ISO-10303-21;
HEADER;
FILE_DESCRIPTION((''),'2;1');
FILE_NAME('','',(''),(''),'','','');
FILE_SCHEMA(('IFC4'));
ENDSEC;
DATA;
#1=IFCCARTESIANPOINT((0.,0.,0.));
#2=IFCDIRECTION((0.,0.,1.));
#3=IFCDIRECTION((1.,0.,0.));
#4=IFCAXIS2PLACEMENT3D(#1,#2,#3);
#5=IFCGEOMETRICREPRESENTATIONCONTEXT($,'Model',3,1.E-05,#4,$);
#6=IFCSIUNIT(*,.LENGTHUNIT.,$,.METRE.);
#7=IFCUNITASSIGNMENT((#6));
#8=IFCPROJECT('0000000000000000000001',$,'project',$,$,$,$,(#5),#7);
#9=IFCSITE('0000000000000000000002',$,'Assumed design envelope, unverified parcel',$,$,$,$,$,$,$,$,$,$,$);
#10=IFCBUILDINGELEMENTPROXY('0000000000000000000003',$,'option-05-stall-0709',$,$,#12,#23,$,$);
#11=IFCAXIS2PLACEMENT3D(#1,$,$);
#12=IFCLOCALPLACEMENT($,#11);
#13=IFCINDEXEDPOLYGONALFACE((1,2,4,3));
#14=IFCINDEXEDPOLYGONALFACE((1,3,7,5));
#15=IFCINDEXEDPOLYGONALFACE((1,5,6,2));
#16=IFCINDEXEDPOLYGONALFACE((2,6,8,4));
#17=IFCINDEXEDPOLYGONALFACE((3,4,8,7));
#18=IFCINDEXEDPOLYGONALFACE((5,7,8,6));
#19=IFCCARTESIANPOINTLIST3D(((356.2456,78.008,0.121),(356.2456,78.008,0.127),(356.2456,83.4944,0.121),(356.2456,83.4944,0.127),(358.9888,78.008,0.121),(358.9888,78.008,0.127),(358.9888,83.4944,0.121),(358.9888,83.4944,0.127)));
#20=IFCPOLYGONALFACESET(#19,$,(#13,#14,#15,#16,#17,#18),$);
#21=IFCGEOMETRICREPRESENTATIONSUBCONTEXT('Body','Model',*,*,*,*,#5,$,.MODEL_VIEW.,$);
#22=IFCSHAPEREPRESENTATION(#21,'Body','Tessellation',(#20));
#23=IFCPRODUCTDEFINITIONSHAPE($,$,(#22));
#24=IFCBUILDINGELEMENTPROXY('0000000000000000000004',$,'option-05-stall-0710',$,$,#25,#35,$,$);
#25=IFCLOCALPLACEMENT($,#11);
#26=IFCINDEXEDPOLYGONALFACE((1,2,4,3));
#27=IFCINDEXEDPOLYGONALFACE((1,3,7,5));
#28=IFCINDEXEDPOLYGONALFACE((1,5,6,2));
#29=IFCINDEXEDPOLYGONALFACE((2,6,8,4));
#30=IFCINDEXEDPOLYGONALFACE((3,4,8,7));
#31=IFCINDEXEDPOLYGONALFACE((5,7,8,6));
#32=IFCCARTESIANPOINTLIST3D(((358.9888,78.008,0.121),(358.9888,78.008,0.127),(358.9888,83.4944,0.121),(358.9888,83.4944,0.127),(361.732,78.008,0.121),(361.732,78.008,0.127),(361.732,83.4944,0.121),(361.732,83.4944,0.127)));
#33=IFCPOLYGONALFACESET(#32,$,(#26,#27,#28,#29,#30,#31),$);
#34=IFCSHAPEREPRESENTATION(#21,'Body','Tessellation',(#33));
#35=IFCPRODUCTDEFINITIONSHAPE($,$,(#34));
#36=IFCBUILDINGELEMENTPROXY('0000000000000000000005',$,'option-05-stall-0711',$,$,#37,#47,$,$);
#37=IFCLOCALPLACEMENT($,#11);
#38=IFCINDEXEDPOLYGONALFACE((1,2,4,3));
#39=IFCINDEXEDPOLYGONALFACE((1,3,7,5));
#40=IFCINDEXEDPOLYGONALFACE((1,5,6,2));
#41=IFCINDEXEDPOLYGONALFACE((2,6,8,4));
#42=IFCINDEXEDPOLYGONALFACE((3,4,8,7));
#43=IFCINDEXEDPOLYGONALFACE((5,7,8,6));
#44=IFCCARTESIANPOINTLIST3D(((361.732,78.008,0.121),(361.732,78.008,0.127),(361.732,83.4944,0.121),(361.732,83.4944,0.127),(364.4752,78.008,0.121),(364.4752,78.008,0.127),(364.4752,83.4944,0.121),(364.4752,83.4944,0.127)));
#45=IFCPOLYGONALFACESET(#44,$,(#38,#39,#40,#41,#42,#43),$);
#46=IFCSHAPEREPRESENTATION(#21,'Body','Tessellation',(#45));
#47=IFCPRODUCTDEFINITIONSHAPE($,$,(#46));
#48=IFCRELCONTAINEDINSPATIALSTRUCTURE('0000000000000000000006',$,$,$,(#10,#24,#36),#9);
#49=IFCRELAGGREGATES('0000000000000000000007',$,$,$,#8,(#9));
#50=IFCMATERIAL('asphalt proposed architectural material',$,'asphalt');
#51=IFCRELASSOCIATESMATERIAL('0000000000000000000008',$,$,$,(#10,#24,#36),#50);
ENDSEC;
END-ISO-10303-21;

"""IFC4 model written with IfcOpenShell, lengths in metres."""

from ifc_helpers import new_model, si_unit, frame, origin_with_axes, place, context, subcontext, project, spatial, rectangle, extrude, material, element, save


model = new_model("IFC4")

# Units and contexts
model_context = context("Model", 3, precision=1e-05, world=origin_with_axes())
body_context = subcontext(model_context, "Body", "Model", "MODEL_VIEW")
ifc_project = project(units=[si_unit("LENGTHUNIT", "METRE")], contexts=[model_context])

# Site
site = spatial("IfcSite", under=ifc_project, Name="Assumed design envelope, unverified parcel")

# Building element proxies
ifc_material = material(Name="asphalt proposed architectural material", Category="asphalt")
for number, where, z_axis, x_axis, name in (
    (1, (357.6172, 80.7512, 0.121), (0.0, 0.0, 1.0), (1.0, 0.0, 0.0), "option-05-stall-0709"),
    (2, (360.3604, 80.7512, 0.121), (0.0, 0.0, 1.0), (1.0, 0.0, 0.0), "option-05-stall-0710"),
    (3, (363.1036, 80.7512, 0.121), (0.0, 0.0, 1.0), (1.0, 0.0, 0.0), "option-05-stall-0711"),
):
    element("IfcBuildingElementProxy", number, at=place(None, frame(where, z_axis=z_axis, x_axis=x_axis)), inside=site, material=ifc_material, Name=name, context=body_context, shape_type="SweptSolid", body=[
        extrude(rectangle(XDim=2.7432, YDim=5.4864), origin_with_axes(), (0.0, 0.0, 1.0), 0.006),
    ])

save(model, "model.ifc")
